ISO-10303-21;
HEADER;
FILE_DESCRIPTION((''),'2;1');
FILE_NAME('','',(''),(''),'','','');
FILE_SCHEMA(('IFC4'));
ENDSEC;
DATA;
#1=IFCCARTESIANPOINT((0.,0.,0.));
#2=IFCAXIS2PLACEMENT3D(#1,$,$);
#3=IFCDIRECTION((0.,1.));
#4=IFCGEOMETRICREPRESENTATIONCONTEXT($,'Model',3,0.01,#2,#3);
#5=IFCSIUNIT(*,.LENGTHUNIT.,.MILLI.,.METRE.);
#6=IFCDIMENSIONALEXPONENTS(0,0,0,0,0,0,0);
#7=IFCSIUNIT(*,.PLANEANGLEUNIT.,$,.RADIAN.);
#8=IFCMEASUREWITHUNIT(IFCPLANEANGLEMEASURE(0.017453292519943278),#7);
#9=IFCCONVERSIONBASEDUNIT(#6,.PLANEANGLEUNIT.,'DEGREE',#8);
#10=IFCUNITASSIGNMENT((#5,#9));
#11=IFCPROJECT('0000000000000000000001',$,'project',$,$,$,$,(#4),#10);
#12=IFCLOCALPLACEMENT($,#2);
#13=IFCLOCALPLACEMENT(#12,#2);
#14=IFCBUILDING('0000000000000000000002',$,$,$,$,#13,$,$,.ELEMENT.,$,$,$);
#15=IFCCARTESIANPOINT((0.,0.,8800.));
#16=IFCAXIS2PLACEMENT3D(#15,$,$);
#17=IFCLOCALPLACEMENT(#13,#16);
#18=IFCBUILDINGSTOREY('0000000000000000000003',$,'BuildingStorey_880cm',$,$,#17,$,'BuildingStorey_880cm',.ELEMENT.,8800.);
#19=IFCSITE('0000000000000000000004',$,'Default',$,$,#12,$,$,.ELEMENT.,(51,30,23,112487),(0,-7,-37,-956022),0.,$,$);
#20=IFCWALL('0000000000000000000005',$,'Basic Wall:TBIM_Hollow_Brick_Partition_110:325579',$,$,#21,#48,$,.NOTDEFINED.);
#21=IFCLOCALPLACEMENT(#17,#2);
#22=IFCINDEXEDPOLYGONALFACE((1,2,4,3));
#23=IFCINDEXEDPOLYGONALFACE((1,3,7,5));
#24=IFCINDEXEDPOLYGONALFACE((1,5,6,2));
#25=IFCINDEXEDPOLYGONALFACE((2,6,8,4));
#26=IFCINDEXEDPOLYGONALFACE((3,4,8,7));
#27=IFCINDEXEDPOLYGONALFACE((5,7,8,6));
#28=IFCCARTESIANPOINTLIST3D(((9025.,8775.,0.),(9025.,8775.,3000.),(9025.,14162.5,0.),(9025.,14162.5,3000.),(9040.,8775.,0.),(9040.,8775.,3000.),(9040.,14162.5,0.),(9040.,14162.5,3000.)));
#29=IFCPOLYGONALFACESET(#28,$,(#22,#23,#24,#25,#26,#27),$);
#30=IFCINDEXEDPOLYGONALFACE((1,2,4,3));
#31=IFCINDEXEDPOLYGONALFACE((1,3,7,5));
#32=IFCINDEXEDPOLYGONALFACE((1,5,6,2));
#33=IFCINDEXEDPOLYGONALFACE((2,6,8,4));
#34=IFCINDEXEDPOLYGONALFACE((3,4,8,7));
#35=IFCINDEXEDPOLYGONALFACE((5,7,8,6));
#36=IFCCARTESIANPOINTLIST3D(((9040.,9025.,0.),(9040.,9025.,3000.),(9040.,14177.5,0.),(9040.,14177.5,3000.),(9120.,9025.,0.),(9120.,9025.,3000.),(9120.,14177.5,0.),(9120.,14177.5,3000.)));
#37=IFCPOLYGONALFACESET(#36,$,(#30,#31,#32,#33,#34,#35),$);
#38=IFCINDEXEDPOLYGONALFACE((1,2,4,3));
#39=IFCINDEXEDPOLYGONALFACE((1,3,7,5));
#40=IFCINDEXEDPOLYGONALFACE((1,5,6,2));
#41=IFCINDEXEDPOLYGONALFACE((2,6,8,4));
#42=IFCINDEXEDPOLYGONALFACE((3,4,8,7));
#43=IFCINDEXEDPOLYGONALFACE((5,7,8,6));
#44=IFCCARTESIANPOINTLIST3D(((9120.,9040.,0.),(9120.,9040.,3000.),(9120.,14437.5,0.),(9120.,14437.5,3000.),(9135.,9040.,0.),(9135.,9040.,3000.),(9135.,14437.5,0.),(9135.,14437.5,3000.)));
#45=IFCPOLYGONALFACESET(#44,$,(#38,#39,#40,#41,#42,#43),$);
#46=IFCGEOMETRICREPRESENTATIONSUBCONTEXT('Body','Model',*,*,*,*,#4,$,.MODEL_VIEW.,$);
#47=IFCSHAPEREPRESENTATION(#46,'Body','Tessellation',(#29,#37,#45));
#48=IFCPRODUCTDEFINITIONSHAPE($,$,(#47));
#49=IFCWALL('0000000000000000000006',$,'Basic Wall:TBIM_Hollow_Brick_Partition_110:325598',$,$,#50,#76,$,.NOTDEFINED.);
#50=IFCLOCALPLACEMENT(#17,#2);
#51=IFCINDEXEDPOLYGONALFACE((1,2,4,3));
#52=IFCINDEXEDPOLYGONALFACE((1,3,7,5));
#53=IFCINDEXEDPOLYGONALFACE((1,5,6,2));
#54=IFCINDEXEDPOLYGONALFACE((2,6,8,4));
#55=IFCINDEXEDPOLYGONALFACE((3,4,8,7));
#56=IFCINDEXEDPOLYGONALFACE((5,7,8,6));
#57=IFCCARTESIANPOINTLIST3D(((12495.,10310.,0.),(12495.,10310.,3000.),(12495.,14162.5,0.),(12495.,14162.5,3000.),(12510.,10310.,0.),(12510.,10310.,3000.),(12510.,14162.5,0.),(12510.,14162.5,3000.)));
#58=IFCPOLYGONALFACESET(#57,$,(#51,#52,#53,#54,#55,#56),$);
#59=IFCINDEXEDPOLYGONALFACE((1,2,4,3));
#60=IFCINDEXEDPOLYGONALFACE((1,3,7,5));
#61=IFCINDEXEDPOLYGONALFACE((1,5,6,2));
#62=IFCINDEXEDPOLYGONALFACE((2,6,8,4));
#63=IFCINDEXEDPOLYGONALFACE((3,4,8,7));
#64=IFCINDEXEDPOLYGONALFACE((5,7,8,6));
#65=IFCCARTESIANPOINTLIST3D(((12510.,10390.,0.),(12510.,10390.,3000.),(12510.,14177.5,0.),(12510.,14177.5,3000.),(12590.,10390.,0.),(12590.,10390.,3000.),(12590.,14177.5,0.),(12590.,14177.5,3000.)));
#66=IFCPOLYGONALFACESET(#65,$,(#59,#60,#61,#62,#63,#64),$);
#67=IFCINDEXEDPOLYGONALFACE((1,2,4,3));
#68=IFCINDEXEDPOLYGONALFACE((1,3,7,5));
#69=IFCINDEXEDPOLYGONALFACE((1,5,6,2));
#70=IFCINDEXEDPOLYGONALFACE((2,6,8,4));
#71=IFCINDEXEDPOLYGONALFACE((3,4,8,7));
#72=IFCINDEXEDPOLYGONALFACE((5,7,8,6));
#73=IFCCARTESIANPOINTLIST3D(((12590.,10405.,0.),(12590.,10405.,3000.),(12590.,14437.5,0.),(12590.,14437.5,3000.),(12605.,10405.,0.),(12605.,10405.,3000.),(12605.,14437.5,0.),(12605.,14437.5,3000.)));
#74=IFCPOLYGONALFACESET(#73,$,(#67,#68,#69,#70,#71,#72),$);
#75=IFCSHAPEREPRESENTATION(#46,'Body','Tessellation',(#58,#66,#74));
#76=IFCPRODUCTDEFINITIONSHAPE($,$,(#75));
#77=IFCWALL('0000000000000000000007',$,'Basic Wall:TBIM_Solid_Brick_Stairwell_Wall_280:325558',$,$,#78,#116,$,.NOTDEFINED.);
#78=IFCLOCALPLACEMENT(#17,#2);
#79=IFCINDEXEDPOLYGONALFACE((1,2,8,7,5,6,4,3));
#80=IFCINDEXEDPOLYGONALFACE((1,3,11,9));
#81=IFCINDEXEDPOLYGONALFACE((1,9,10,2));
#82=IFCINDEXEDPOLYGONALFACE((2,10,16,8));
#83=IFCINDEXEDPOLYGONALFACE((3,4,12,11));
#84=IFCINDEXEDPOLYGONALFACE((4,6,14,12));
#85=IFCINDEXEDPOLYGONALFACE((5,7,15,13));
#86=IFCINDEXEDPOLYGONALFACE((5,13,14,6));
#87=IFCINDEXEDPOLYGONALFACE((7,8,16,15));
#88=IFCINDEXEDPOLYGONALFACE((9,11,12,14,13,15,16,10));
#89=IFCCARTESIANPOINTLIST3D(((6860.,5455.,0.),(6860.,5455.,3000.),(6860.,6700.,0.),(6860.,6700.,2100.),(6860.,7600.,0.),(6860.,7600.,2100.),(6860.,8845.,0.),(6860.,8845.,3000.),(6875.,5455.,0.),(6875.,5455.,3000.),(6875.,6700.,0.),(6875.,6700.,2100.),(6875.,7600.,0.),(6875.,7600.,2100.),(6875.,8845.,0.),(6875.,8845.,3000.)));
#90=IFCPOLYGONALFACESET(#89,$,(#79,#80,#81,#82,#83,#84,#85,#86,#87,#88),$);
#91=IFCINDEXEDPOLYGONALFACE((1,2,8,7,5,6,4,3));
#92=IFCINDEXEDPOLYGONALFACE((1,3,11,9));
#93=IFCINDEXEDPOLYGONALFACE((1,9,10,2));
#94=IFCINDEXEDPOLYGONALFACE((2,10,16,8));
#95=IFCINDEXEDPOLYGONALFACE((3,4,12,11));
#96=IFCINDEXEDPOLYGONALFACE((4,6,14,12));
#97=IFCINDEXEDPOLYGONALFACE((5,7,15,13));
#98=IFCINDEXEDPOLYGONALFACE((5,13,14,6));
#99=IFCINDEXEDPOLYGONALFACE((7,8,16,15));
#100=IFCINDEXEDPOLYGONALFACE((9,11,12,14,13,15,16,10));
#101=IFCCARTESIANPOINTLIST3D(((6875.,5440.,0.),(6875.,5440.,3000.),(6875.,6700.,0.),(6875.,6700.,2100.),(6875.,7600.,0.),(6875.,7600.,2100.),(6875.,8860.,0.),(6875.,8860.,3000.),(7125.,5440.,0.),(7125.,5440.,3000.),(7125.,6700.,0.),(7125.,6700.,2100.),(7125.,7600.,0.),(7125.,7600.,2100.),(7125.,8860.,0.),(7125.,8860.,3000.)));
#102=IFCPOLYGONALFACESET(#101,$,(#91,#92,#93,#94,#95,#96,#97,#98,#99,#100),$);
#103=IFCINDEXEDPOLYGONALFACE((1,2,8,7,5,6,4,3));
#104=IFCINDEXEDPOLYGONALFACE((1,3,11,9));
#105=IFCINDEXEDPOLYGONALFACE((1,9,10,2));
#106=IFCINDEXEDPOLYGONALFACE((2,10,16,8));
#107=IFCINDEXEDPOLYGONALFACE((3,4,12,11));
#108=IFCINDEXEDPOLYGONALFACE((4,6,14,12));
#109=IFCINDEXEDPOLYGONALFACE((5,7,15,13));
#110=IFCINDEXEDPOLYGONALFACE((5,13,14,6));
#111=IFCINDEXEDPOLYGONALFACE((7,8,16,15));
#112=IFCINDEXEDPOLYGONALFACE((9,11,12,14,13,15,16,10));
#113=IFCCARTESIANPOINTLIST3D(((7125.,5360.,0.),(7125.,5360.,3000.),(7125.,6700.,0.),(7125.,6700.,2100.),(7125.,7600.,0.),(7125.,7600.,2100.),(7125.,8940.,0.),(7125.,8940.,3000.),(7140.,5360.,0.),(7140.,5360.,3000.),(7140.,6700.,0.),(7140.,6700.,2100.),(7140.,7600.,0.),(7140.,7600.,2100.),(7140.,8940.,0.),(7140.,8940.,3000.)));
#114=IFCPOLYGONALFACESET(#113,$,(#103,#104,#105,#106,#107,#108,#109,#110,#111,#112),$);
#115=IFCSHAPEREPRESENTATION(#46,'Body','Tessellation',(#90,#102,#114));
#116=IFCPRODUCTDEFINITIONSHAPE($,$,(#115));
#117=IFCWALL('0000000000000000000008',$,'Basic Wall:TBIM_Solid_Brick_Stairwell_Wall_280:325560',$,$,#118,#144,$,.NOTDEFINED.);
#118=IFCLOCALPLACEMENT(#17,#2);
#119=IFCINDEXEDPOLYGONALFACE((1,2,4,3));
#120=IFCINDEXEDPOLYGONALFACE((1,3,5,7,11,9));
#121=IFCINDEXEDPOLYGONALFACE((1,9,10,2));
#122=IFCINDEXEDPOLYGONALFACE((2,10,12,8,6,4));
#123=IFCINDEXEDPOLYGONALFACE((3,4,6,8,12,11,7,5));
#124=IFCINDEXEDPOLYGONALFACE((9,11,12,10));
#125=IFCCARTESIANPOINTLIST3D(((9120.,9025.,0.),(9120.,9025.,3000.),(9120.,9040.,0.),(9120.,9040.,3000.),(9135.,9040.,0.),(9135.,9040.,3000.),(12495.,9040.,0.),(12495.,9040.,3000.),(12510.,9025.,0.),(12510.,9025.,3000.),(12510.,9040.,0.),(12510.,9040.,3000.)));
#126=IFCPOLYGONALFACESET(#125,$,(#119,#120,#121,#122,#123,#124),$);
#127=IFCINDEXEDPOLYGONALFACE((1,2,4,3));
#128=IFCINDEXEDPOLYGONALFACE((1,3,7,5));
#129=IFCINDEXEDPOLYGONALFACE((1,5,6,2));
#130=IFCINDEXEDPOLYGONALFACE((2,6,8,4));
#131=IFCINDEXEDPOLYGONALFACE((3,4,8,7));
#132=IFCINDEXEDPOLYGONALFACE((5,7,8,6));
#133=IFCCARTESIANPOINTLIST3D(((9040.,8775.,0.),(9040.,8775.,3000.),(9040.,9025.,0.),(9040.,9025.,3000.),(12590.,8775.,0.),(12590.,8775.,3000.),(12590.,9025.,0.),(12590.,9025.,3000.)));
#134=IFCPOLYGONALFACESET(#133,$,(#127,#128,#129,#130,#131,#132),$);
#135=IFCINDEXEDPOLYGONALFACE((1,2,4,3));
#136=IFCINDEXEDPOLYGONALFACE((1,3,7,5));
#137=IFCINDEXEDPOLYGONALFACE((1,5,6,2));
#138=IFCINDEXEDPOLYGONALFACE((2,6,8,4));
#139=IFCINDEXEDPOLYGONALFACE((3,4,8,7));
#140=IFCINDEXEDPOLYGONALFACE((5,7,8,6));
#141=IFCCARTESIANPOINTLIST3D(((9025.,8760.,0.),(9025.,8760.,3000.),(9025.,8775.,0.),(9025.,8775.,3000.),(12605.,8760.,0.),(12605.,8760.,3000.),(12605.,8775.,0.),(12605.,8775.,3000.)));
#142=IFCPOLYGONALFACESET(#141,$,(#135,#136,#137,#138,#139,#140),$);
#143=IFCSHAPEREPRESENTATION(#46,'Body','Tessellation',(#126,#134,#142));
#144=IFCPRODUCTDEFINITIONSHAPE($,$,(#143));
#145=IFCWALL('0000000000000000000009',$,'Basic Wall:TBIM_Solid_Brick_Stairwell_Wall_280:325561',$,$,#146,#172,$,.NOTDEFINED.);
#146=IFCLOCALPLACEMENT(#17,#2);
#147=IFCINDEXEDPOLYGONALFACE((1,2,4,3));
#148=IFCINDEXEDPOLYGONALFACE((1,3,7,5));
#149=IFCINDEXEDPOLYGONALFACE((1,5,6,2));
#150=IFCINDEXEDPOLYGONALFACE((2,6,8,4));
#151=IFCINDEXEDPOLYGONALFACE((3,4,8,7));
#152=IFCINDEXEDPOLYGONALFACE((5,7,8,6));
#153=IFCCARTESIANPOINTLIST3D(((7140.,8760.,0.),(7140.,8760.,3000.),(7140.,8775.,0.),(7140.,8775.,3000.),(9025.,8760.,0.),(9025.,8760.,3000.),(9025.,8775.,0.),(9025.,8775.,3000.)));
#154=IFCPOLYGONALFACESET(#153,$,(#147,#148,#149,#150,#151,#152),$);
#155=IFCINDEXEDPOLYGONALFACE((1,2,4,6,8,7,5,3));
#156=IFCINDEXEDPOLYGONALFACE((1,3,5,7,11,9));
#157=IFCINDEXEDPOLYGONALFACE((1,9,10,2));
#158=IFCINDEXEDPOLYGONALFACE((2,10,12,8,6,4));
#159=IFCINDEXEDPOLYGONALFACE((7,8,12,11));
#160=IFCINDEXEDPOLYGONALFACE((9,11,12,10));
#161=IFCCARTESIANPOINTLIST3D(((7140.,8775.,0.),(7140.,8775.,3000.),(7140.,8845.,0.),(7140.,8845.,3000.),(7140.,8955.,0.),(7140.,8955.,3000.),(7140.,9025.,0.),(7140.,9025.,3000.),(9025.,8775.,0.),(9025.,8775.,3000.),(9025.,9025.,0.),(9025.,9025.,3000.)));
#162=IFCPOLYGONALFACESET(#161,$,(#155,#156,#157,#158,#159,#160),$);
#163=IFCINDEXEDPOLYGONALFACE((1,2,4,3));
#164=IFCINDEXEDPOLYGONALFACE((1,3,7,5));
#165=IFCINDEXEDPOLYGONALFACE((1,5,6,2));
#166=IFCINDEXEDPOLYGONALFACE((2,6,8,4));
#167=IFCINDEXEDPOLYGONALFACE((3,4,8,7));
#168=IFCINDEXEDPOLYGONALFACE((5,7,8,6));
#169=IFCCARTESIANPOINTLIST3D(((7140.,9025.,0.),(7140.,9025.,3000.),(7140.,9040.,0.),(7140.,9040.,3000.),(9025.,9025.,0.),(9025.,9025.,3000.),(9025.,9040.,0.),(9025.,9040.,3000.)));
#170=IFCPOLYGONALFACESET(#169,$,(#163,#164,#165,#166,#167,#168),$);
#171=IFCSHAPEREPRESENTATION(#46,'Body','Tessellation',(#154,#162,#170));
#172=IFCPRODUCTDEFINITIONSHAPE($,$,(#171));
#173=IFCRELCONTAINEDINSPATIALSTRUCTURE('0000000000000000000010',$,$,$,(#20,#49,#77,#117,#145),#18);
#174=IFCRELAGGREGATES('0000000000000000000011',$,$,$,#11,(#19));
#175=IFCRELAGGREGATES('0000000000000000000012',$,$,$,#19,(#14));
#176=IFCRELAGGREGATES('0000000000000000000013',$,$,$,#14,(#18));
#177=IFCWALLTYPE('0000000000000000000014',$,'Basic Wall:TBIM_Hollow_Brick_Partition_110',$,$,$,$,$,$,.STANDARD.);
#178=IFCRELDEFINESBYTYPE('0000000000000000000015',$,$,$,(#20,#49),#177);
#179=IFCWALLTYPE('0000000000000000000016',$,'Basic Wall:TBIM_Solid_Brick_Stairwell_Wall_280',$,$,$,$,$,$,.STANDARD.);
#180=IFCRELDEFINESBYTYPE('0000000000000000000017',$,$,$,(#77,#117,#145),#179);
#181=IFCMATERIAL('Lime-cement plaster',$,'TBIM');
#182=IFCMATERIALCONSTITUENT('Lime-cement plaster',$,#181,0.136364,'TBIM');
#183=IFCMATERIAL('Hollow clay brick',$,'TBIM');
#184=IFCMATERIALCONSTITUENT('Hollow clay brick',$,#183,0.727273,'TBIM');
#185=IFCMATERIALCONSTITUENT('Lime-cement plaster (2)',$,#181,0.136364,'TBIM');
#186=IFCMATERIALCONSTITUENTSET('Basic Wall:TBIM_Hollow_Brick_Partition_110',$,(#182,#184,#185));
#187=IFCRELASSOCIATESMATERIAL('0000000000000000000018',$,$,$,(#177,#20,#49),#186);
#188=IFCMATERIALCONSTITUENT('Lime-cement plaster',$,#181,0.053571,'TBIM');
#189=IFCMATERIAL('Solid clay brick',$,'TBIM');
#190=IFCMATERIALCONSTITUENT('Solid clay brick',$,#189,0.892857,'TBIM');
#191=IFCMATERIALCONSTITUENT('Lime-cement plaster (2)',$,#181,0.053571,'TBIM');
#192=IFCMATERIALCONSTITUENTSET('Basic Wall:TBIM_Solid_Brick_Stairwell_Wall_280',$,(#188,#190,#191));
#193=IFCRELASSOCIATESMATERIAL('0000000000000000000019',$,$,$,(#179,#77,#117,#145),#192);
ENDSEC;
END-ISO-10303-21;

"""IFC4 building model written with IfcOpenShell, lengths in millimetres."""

from ifc_helpers import new_model, entity, si_unit, converted_unit, direction, frame, origin, place, context, subcontext, project, spatial, indexed_curve, outline, extrude, material, constituent, constituent_set, type_object, element, save


model = new_model("IFC4")

# Units and contexts
model_context = context("Model", 3, precision=0.01, world=origin(), true_north=direction((0.0, 1.0)))
body_context = subcontext(model_context, "Body", "Model", "MODEL_VIEW")
ifc_project = project(units=[si_unit("LENGTHUNIT", "METRE", prefix="MILLI"), converted_unit("PLANEANGLEUNIT", "DEGREE", entity("IfcPlaneAngleMeasure", 0.017453292519943278), si_unit("PLANEANGLEUNIT", "RADIAN"), dimensions=[0, 0, 0, 0, 0, 0, 0])], contexts=[model_context])

# Site, building, storey
site_placement = place(None, origin())
site = spatial("IfcSite", under=ifc_project, at=site_placement, Name="Default", CompositionType="ELEMENT", RefLatitude=(51, 30, 23, 112487), RefLongitude=(0, -7, -37, -956022), RefElevation=0.0)
building_placement = place(site_placement, origin())
building = spatial("IfcBuilding", under=site, at=building_placement, CompositionType="ELEMENT")
storey_placement = place(building_placement, frame((0.0, 0.0, 8800.0)))
storey = spatial("IfcBuildingStorey", under=building, at=storey_placement, Name="BuildingStorey_880cm", LongName="BuildingStorey_880cm", CompositionType="ELEMENT", Elevation=8800.0)

# Shared definitions
ifc_material_1 = material(Name="Hollow clay brick", Category="TBIM")
ifc_material_2 = material(Name="Lime-cement plaster", Category="TBIM")
ifc_constituent_1 = constituent(ifc_material_2, Name="Lime-cement plaster", Category="TBIM", fraction=0.136364)
ifc_constituent_2 = constituent(ifc_material_1, Name="Hollow clay brick", Category="TBIM", fraction=0.727273)
ifc_constituent_3 = constituent(ifc_material_2, Name="Lime-cement plaster (2)", Category="TBIM", fraction=0.136364)
ifc_constituent_set_1 = constituent_set(constituents=[ifc_constituent_1, ifc_constituent_2, ifc_constituent_3], Name="Basic Wall:TBIM_Hollow_Brick_Partition_110")
wall_type_1 = type_object("IfcWallType", Name="Basic Wall:TBIM_Hollow_Brick_Partition_110", PredefinedType="STANDARD", material=ifc_constituent_set_1)

# Walls
wall_1_placement = place(storey_placement, frame((9080.0, 9040.0, 0.0), z_axis=(0.0, 0.0, 1.0), x_axis=(0.0, 1.0, 0.0)))
element("IfcWall", 1, at=wall_1_placement, inside=storey, type_object=wall_type_1, material=ifc_constituent_set_1, Name="Basic Wall:TBIM_Hollow_Brick_Partition_110:325579", PredefinedType="NOTDEFINED", context=body_context, shape_type="SweptSolid", body=[
    extrude(outline(indexed_curve([(-7.5, -2693.7), (7.5, -2693.7), (7.5, 2693.8), (-7.5, 2693.8), (-7.5, -2693.7)], self_intersect=False)), frame((2428.7, 47.5, 0.0), z_axis=(0.0, 0.0, 1.0), x_axis=(0.0, -1.0, 0.0)), (0.0, 0.0, 1.0), 3000.0),
    extrude(outline(indexed_curve([(-2576.2, -40.0), (2576.3, -40.0), (2576.3, 40.0), (-2576.2, 40.0), (-2576.2, -40.0)], self_intersect=False)), frame((2561.2, 0.0, 0.0)), (0.0, 0.0, 1.0), 3000.0),
    extrude(outline(indexed_curve([(-7.5, -2698.7), (7.5, -2698.7), (7.5, 2698.8), (-7.5, 2698.8), (-7.5, -2698.7)], self_intersect=False)), frame((2698.8, -47.5, 0.0), z_axis=(0.0, 0.0, 1.0), x_axis=(0.0, 1.0, 0.0)), (0.0, 0.0, 1.0), 3000.0),
])
wall_2_placement = place(storey_placement, frame((12550.0, 10405.0, 0.0), z_axis=(0.0, 0.0, 1.0), x_axis=(0.0, 1.0, 0.0)))
element("IfcWall", 2, at=wall_2_placement, inside=storey, type_object=wall_type_1, material=ifc_constituent_set_1, Name="Basic Wall:TBIM_Hollow_Brick_Partition_110:325598", PredefinedType="NOTDEFINED", context=body_context, shape_type="SweptSolid", body=[
    extrude(outline(indexed_curve([(-7.5, -1926.2), (7.5, -1926.2), (7.5, 1926.2), (-7.5, 1926.2), (-7.5, -1926.2)], self_intersect=False)), frame((1831.2, 47.5, 0.0), z_axis=(0.0, 0.0, 1.0), x_axis=(0.0, -1.0, 0.0)), (0.0, 0.0, 1.0), 3000.0),
    extrude(outline(indexed_curve([(-1893.8, -40.0), (1893.8, -40.0), (1893.8, 40.0), (-1893.8, 40.0), (-1893.8, -40.0)], self_intersect=False)), frame((1878.7, 0.0, 0.0)), (0.0, 0.0, 1.0), 3000.0),
    extrude(outline(indexed_curve([(-7.5, -2016.3), (7.5, -2016.3), (7.5, 2016.2), (-7.5, 2016.2), (-7.5, -2016.3)], self_intersect=False)), frame((2016.2, -47.5, 0.0), z_axis=(0.0, 0.0, 1.0), x_axis=(0.0, 1.0, 0.0)), (0.0, 0.0, 1.0), 3000.0),
])
ifc_constituent_4 = constituent(ifc_material_2, Name="Lime-cement plaster", Category="TBIM", fraction=0.053571)
ifc_material_3 = material(Name="Solid clay brick", Category="TBIM")
ifc_constituent_5 = constituent(ifc_material_3, Name="Solid clay brick", Category="TBIM", fraction=0.892857)
ifc_constituent_6 = constituent(ifc_material_2, Name="Lime-cement plaster (2)", Category="TBIM", fraction=0.053571)
ifc_constituent_set_2 = constituent_set(constituents=[ifc_constituent_4, ifc_constituent_5, ifc_constituent_6], Name="Basic Wall:TBIM_Solid_Brick_Stairwell_Wall_280")
wall_type_2 = type_object("IfcWallType", Name="Basic Wall:TBIM_Solid_Brick_Stairwell_Wall_280", PredefinedType="STANDARD", material=ifc_constituent_set_2)

# Wall, opening
wall_3_placement = place(storey_placement, frame((7000.0, 5455.0, 0.0), z_axis=(0.0, 0.0, 1.0), x_axis=(0.0, 1.0, 0.0)))
wall_3 = element("IfcWall", 3, at=wall_3_placement, inside=storey, type_object=wall_type_2, material=ifc_constituent_set_2, Name="Basic Wall:TBIM_Solid_Brick_Stairwell_Wall_280:325558", PredefinedType="NOTDEFINED", context=body_context, shape_type="SweptSolid", body=[
    extrude(outline(indexed_curve([(-1725.0, -1695.0), (1275.0, -1695.0), (1275.0, -450.0), (-825.0, -450.0), (-825.0, 450.0), (1275.0, 450.0), (1275.0, 1695.0), (-1725.0, 1695.0), (-1725.0, -1695.0)], self_intersect=False)), frame((1695.0, 140.0, 1275.0), z_axis=(0.0, -1.0, 0.0), x_axis=(0.0, 0.0, -1.0)), (0.0, 0.0, 1.0), 15.0),
    extrude(outline(indexed_curve([(-1275.0, -450.0), (-1275.0, -1710.0), (1725.0, -1710.0), (1725.0, 1710.0), (-1275.0, 1710.0), (-1275.0, 450.0), (825.0, 450.0), (825.0, -450.0), (-1275.0, -450.0)], self_intersect=False)), frame((1695.0, 125.0, 1275.0), z_axis=(0.0, 1.0, 0.0), x_axis=(0.0, 0.0, 1.0)), (0.0, 0.0, -1.0), 250.0),
    extrude(outline(indexed_curve([(-1275.0, -450.0), (-1275.0, -1790.0), (1725.0, -1790.0), (1725.0, 1790.0), (-1275.0, 1790.0), (-1275.0, 450.0), (825.0, 450.0), (825.0, -450.0), (-1275.0, -450.0)], self_intersect=False)), frame((1695.0, -125.0, 1275.0), z_axis=(0.0, 1.0, 0.0), x_axis=(0.0, 0.0, 1.0)), (0.0, 0.0, -1.0), 15.0),
])
opening_1_placement = place(wall_3_placement, frame((1245.0, -140.0, 0.0)))
element("IfcOpeningElement", 4, at=opening_1_placement, cuts=wall_3, PredefinedType="OPENING", context=body_context, shape_type="SweptSolid", body=[
    extrude(outline(indexed_curve([(0.0, 900.0), (0.0, 0.0), (2100.0, 0.0), (2100.0, 900.0), (0.0, 900.0)], self_intersect=False)), frame((0.0, 0.0, 0.0), z_axis=(0.0, 1.0, 0.0), x_axis=(0.0, 0.0, 1.0)), (0.0, 0.0, 1.0), 280.0),
])

# Walls
wall_4_placement = place(storey_placement, frame((9025.0, 8900.0, 0.0)))
element("IfcWall", 5, at=wall_4_placement, inside=storey, type_object=wall_type_2, material=ifc_constituent_set_2, Name="Basic Wall:TBIM_Solid_Brick_Stairwell_Wall_280:325560", PredefinedType="NOTDEFINED", context=body_context, shape_type="SweptSolid", body=[
    extrude(outline(indexed_curve([(-1680.0, -5.0), (1680.0, -5.0), (1695.0, -5.0), (1695.0, 10.0), (-1695.0, 10.0), (-1695.0, -5.0), (-1680.0, -5.0)], self_intersect=False)), frame((1790.0, 135.0, 0.0), z_axis=(0.0, 0.0, 1.0), x_axis=(-1.0, 0.0, 0.0)), (0.0, 0.0, 1.0), 3000.0),
    extrude(outline(indexed_curve([(-1775.0, -125.0), (1775.0, -125.0), (1775.0, 125.0), (-1775.0, 125.0), (-1775.0, -125.0)], self_intersect=False)), frame((1790.0, 0.0, 0.0)), (0.0, 0.0, 1.0), 3000.0),
    extrude(outline(indexed_curve([(-7.5, -1790.0), (7.5, -1790.0), (7.5, 1790.0), (-7.5, 1790.0), (-7.5, -1790.0)], self_intersect=False)), frame((1790.0, -132.5, 0.0), z_axis=(0.0, 0.0, 1.0), x_axis=(0.0, 1.0, 0.0)), (0.0, 0.0, 1.0), 3000.0),
])
wall_5_placement = place(storey_placement, frame((9025.0, 8900.0, 0.0), z_axis=(0.0, 0.0, 1.0), x_axis=(-1.0, 0.0, 0.0)))
element("IfcWall", 6, at=wall_5_placement, inside=storey, type_object=wall_type_2, material=ifc_constituent_set_2, Name="Basic Wall:TBIM_Solid_Brick_Stairwell_Wall_280:325561", PredefinedType="NOTDEFINED", context=body_context, shape_type="SweptSolid", body=[
    extrude(outline(indexed_curve([(-7.5, -942.5), (7.5, -942.5), (7.5, 942.5), (-7.5, 942.5), (-7.5, -942.5)], self_intersect=False)), frame((942.5, 132.5, 0.0), z_axis=(0.0, 0.0, 1.0), x_axis=(0.0, -1.0, 0.0)), (0.0, 0.0, 1.0), 3000.0),
    extrude(outline(indexed_curve([(55.0, -628.3), (125.0, -628.3), (125.0, 1256.7), (-125.0, 1256.7), (-125.0, -628.3), (-55.0, -628.3), (55.0, -628.3)], self_intersect=False)), frame((1256.7, 0.0, 0.0), z_axis=(0.0, 0.0, 1.0), x_axis=(0.0, 1.0, 0.0)), (0.0, 0.0, 1.0), 3000.0),
    extrude(outline(indexed_curve([(-7.5, -942.5), (7.5, -942.5), (7.5, 942.5), (-7.5, 942.5), (-7.5, -942.5)], self_intersect=False)), frame((942.5, -132.5, 0.0), z_axis=(0.0, 0.0, 1.0), x_axis=(0.0, 1.0, 0.0)), (0.0, 0.0, 1.0), 3000.0),
])

save(model, "model.ifc")
